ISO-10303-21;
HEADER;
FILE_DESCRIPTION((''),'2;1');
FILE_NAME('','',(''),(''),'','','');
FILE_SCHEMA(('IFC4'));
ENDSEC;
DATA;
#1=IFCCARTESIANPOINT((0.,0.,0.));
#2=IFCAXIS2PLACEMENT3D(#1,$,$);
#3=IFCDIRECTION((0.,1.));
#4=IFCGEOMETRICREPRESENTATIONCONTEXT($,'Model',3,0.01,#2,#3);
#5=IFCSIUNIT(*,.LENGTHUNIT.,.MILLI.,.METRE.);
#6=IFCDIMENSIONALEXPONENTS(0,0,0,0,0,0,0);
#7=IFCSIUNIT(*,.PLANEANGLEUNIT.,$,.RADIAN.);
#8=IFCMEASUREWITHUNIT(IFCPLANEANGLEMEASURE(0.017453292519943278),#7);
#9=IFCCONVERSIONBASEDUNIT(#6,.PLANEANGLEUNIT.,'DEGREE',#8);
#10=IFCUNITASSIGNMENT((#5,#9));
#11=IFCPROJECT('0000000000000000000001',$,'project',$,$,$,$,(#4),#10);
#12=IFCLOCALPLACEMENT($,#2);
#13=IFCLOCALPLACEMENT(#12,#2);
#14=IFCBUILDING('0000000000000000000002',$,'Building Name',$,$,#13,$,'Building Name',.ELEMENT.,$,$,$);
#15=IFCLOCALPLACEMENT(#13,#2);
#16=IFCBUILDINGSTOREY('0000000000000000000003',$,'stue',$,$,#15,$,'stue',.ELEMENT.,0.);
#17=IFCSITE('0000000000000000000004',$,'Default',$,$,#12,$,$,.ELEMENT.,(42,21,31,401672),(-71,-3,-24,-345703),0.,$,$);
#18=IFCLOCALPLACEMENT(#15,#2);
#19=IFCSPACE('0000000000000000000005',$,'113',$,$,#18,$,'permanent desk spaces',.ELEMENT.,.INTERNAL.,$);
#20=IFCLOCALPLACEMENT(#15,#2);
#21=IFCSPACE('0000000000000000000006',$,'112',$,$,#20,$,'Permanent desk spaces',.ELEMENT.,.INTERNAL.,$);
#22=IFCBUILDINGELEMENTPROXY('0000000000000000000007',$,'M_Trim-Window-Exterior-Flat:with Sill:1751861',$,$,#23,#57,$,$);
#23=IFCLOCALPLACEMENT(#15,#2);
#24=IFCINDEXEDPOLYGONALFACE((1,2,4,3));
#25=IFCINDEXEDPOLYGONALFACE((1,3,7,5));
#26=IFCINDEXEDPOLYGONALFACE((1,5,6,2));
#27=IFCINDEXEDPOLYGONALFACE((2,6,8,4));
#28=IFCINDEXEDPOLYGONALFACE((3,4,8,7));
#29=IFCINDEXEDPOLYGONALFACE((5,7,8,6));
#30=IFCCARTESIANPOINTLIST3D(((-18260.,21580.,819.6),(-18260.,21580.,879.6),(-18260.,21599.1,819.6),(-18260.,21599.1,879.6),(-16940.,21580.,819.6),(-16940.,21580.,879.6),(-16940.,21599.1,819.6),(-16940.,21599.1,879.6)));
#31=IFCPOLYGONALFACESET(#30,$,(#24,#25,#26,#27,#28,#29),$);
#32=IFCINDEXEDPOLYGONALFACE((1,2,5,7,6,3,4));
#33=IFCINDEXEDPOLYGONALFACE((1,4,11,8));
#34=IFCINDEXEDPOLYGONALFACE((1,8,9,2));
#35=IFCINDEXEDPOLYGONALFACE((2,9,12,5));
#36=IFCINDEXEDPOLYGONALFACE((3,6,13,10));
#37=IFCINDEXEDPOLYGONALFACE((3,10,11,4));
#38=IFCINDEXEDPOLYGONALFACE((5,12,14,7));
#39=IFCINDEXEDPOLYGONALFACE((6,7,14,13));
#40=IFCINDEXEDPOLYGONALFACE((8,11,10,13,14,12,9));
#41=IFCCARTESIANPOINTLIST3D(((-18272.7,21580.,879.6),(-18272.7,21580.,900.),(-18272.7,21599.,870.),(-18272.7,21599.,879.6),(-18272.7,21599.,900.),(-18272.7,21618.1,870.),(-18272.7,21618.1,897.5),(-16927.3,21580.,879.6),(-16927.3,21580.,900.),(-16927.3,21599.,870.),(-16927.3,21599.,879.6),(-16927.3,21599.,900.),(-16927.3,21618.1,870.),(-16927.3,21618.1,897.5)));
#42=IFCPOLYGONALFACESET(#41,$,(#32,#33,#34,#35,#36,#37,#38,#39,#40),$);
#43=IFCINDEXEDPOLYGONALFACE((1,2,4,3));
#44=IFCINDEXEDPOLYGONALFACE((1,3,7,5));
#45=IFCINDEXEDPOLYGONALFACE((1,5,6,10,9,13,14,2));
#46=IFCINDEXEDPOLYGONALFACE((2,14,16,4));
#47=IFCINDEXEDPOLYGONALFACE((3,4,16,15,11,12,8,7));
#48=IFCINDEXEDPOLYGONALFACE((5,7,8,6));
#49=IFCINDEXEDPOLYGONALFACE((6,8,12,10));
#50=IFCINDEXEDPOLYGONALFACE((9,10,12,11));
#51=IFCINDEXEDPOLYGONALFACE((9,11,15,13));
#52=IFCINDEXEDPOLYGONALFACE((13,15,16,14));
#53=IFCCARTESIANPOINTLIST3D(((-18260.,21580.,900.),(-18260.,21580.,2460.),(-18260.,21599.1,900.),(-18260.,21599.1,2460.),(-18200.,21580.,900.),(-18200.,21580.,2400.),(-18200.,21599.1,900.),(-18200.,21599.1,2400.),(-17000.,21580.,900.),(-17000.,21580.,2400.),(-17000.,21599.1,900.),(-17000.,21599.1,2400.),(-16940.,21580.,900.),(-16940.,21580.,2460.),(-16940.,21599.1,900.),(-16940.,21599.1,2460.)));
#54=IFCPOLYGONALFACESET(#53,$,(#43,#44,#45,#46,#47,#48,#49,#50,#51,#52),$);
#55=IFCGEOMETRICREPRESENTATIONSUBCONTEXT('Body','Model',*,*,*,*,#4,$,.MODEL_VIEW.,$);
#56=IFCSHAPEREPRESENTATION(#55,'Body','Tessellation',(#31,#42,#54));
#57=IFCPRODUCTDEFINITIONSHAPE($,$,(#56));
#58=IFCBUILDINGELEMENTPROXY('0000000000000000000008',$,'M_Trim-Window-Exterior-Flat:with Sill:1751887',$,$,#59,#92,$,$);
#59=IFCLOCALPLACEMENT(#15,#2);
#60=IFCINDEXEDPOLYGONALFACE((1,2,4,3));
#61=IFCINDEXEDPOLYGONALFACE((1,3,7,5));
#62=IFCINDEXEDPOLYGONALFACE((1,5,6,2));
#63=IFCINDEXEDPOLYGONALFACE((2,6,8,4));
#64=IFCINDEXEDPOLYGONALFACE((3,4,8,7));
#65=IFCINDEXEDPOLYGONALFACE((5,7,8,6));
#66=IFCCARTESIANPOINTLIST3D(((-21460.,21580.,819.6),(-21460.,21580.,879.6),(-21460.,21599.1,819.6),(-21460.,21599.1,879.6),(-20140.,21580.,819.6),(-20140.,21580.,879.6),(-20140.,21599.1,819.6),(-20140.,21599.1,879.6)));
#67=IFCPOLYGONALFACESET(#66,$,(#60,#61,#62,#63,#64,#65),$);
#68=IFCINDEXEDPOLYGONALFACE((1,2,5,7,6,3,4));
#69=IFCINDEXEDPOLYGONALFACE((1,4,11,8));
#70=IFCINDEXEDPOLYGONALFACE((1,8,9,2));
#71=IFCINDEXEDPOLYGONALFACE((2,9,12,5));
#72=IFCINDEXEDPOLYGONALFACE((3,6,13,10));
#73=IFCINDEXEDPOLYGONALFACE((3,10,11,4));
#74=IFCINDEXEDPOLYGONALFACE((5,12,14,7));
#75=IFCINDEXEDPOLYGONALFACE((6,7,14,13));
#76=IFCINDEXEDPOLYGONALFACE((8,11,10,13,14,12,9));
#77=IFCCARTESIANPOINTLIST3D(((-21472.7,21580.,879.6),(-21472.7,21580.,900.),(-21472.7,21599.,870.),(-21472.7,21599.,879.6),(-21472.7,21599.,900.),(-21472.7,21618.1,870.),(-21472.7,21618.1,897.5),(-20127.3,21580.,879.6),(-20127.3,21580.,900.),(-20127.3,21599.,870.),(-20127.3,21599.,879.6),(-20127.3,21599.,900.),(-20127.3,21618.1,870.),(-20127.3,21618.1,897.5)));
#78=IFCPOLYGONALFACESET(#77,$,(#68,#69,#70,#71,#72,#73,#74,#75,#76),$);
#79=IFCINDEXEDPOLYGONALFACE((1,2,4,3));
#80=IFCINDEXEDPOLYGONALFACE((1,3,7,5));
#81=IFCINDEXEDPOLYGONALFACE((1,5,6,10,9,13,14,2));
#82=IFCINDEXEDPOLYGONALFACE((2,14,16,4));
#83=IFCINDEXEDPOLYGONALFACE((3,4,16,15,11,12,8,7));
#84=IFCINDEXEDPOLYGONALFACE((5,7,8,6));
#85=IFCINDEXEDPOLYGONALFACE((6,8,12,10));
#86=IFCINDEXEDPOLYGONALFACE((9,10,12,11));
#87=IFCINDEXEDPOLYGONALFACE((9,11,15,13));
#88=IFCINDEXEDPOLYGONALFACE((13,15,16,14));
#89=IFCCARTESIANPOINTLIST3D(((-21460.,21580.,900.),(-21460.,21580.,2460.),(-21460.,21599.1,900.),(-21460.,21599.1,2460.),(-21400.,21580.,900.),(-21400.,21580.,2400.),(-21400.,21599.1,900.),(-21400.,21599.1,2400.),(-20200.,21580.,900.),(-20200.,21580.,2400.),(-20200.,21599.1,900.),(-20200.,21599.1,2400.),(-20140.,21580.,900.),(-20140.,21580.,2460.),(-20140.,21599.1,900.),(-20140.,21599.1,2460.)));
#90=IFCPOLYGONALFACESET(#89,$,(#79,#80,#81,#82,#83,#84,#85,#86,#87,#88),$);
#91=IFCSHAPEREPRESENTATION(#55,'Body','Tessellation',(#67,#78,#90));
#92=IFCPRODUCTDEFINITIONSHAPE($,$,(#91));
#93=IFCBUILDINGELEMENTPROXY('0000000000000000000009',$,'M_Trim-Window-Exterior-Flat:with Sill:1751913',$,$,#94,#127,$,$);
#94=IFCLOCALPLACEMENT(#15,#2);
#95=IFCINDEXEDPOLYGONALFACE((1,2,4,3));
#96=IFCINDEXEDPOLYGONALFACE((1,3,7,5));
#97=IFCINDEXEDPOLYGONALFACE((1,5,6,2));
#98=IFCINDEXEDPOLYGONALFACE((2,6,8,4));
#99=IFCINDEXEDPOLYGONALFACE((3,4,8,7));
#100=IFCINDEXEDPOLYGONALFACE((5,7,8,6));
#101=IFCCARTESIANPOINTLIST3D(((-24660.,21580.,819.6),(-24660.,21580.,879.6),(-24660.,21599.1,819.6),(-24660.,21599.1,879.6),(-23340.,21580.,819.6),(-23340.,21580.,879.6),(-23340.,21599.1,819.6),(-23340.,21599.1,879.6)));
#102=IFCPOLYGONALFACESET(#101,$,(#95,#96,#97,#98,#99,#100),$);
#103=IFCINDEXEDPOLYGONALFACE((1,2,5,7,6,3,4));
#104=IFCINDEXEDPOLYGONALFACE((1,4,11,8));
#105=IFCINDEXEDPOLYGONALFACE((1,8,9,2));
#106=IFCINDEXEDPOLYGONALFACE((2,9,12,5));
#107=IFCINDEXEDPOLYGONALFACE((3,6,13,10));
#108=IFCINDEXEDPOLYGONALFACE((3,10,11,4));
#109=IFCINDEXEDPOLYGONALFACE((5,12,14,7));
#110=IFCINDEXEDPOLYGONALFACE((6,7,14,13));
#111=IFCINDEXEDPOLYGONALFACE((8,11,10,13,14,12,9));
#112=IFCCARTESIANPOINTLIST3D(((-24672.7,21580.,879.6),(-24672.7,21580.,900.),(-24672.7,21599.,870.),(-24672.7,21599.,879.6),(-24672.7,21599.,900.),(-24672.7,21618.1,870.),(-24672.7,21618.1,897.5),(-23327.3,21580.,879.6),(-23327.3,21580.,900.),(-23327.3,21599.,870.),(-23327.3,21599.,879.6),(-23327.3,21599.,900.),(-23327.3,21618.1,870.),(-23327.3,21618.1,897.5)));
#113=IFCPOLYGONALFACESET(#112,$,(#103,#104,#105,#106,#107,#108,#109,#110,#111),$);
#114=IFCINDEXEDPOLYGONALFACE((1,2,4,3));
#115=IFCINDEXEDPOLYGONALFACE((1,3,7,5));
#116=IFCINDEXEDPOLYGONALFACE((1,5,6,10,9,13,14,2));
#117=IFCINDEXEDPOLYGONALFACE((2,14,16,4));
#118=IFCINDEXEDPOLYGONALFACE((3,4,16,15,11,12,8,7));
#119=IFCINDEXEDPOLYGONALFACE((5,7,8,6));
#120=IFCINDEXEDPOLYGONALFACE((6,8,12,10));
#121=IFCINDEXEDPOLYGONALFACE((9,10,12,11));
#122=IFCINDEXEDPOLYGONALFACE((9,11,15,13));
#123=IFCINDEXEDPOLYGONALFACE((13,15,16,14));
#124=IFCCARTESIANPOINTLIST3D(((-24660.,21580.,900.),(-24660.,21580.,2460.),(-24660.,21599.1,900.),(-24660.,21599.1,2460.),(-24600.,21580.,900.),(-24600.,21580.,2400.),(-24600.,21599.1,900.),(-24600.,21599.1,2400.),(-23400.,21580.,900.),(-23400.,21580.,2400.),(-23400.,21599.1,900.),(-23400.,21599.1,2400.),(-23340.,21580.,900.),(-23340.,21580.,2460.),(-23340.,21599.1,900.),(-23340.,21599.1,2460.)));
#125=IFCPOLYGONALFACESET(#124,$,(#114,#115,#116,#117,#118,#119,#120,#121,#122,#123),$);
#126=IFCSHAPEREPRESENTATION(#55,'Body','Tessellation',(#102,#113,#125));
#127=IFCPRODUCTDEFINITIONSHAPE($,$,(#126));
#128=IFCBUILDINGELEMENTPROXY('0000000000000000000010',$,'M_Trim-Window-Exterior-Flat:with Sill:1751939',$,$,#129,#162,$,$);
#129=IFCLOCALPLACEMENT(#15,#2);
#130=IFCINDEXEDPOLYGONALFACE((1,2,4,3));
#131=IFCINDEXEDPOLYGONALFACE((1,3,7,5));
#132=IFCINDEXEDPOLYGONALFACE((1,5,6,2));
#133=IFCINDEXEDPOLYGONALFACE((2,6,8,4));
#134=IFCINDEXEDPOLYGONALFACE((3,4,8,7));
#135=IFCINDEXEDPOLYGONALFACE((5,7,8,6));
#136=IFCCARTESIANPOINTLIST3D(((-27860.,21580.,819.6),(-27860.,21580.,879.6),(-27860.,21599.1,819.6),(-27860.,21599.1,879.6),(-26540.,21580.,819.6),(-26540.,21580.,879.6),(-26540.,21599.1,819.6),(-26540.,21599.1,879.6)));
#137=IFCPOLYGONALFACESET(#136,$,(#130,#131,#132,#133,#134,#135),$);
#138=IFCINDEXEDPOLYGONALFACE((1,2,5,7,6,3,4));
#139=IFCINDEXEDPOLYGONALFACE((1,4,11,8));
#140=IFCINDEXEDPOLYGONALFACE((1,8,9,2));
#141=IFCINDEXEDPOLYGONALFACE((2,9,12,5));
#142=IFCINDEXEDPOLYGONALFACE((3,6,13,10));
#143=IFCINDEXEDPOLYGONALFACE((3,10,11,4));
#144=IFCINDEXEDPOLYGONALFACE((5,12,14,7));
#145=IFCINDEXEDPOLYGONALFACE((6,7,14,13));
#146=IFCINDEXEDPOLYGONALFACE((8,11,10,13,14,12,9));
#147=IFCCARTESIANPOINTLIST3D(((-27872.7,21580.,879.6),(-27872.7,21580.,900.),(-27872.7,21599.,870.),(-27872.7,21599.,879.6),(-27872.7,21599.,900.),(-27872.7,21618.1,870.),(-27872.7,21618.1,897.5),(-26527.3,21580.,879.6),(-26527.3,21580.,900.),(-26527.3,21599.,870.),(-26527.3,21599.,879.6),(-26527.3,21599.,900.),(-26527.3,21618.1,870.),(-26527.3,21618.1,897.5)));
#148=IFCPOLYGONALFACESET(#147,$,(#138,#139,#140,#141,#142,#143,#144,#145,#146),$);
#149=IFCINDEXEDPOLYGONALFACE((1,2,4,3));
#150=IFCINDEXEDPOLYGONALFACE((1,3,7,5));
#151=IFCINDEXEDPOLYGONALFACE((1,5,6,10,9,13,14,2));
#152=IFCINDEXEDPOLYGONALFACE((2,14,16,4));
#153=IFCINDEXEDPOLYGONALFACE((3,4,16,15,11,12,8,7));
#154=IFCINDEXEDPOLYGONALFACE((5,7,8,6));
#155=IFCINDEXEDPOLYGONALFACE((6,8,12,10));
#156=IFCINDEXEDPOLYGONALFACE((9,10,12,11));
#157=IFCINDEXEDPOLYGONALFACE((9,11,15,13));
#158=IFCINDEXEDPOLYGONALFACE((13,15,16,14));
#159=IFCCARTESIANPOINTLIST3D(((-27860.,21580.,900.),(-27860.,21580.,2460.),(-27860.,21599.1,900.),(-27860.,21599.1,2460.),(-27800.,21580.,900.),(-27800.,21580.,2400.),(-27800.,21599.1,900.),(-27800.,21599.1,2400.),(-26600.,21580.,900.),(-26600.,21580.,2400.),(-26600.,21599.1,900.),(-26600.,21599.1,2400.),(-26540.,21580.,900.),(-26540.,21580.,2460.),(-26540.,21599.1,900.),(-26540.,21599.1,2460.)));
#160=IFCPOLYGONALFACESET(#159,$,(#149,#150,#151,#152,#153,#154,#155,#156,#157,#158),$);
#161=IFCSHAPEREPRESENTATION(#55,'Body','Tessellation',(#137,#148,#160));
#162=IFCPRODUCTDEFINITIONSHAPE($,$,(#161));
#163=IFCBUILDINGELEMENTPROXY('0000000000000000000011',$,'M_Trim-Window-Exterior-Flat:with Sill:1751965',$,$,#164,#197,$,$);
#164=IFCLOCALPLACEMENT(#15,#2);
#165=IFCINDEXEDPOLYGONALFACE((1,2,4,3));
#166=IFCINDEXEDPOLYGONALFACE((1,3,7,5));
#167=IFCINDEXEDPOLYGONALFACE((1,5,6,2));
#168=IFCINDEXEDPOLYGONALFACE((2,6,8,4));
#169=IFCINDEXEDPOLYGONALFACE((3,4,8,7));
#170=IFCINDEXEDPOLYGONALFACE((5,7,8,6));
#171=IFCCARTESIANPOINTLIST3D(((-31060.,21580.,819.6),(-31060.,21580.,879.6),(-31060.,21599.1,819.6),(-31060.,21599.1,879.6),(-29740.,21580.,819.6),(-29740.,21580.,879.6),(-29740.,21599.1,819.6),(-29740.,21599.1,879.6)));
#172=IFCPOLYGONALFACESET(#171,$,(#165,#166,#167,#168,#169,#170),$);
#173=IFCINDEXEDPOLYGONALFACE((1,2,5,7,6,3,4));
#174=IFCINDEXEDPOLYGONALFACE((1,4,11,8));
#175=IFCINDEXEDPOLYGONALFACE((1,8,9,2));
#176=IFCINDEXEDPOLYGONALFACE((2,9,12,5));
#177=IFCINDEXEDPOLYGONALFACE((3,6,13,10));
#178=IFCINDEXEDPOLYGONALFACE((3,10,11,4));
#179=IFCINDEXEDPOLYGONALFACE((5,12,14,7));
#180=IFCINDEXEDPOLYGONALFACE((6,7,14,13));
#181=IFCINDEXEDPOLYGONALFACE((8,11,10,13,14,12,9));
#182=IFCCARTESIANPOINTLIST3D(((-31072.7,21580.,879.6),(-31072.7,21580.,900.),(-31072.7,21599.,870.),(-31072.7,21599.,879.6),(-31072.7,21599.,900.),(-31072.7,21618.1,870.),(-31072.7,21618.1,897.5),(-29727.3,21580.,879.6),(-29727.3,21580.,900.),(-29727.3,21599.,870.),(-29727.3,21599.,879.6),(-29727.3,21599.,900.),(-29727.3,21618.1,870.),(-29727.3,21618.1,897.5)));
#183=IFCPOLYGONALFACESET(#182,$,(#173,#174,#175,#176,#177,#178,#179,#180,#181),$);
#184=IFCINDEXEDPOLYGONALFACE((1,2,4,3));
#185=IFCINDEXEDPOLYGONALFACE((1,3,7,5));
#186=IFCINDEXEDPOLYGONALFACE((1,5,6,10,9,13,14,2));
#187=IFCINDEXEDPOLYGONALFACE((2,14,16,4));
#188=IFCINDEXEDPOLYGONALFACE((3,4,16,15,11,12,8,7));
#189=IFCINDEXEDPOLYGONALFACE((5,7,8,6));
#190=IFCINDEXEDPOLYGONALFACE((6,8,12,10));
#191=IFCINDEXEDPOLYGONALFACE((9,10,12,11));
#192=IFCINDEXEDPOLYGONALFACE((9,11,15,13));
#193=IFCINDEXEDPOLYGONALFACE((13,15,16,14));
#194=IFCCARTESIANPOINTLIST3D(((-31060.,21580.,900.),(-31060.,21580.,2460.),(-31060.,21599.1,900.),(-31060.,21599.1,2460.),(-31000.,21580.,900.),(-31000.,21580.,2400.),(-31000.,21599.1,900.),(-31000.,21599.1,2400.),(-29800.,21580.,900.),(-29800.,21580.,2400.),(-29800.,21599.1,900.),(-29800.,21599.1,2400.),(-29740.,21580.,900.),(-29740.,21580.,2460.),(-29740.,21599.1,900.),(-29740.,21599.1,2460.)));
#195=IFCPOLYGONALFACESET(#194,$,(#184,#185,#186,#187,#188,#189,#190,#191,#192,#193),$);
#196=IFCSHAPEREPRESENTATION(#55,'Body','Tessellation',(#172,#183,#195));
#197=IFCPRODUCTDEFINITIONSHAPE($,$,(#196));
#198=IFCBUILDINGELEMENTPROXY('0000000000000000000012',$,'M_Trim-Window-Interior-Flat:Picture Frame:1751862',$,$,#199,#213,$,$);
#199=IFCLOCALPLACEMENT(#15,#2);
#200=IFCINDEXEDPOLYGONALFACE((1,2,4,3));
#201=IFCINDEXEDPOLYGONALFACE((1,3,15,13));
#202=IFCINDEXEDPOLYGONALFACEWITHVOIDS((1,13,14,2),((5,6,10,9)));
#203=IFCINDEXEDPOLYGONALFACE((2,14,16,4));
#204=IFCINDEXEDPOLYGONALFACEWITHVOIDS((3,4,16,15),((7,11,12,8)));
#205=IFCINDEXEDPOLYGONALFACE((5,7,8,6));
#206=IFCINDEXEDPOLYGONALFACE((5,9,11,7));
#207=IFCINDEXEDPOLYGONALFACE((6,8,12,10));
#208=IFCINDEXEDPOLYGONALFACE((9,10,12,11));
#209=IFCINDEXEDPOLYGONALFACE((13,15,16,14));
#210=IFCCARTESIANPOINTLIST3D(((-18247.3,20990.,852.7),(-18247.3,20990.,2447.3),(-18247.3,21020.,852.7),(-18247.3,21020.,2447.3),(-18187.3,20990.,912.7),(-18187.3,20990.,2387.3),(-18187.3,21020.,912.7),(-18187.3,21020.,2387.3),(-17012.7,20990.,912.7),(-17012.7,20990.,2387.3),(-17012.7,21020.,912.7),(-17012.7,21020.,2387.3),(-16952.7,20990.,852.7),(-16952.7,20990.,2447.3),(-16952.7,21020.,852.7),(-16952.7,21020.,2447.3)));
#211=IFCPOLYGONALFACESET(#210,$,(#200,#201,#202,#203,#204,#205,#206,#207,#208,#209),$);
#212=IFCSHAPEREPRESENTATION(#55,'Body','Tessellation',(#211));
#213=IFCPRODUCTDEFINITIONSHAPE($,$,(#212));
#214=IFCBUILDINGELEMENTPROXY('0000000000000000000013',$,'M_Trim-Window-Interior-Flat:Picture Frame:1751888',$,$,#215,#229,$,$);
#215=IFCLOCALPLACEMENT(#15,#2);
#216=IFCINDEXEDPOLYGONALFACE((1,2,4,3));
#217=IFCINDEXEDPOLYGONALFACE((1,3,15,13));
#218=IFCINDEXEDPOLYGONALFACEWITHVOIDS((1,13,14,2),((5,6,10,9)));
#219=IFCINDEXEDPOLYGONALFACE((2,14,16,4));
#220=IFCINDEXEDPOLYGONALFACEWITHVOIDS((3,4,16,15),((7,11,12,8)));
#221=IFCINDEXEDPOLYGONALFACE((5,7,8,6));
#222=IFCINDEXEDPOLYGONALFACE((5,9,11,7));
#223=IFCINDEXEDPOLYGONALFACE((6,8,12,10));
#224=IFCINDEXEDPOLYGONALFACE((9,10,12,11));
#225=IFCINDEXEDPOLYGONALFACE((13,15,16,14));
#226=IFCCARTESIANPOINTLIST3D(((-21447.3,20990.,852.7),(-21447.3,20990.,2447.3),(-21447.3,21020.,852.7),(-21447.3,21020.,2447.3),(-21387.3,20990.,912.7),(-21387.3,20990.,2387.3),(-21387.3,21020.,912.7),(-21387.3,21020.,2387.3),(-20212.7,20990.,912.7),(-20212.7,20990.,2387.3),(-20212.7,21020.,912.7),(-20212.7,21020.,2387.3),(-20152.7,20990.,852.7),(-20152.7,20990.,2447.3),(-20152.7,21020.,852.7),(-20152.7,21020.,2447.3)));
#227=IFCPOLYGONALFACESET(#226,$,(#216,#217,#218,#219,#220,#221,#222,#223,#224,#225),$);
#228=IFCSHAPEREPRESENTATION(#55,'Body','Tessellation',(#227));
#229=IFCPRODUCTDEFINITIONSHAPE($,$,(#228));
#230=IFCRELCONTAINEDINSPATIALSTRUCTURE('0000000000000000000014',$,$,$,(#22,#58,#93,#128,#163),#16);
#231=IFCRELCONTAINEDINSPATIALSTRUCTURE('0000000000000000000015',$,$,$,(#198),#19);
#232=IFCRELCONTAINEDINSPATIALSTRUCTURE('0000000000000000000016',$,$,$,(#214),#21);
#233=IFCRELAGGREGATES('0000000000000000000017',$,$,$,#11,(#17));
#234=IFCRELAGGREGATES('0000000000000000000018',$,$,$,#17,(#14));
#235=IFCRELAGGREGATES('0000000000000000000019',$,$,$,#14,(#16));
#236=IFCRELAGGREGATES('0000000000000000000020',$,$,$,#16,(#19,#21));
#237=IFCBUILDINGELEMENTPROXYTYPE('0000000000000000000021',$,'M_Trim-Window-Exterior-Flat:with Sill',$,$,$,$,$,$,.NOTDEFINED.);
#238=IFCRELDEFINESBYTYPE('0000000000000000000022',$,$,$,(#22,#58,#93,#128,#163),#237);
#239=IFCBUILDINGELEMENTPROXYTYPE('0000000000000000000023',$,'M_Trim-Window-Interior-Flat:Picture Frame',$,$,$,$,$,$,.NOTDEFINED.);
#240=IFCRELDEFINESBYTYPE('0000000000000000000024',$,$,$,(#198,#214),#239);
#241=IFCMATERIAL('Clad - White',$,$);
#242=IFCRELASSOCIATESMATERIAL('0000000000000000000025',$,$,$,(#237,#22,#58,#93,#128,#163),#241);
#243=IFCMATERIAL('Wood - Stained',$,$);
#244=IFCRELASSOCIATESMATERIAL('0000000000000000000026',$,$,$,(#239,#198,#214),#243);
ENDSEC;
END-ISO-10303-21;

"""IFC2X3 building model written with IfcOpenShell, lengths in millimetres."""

from ifc_helpers import new_model, entity, si_unit, converted_unit, direction, frame, frame_2d, origin, place, context, subcontext, project, spatial, polyline, rectangle, outline, extrude, source, transform, mapped, material, type_object, type_shapes, element, save


model = new_model("IFC2X3")

# Units and contexts
model_context = context("Model", 3, precision=0.01, world=origin(), true_north=direction((0.0, 1.0)))
body_context = subcontext(model_context, "Body", "Model", "MODEL_VIEW")
ifc_project = project(units=[si_unit("LENGTHUNIT", "METRE", prefix="MILLI"), converted_unit("PLANEANGLEUNIT", "DEGREE", entity("IfcPlaneAngleMeasure", 0.017453292519943278), si_unit("PLANEANGLEUNIT", "RADIAN"), dimensions=[0, 0, 0, 0, 0, 0, 0])], contexts=[model_context])

# Site, building, storey
site_placement = place(None, origin())
site = spatial("IfcSite", under=ifc_project, at=site_placement, Name="Default", CompositionType="ELEMENT", RefLatitude=(42, 21, 31, 401672), RefLongitude=(-71, -3, -24, -345703), RefElevation=0.0)
building_placement = place(site_placement, origin())
building = spatial("IfcBuilding", under=site, at=building_placement, Name="Building Name", LongName="Building Name", CompositionType="ELEMENT")
storey_placement = place(building_placement, origin())
storey = spatial("IfcBuildingStorey", under=building, at=storey_placement, Name="stue", LongName="stue", CompositionType="ELEMENT", Elevation=0.0)

# Building element proxies
ifc_material_1 = material(Name="Clad - White")
ifc_material_2 = material(Name="Wood - Stained")
building_element_proxy_type_1 = type_object("IfcBuildingElementProxyType", Name="M_Trim-Window-Exterior-Flat:with Sill", PredefinedType="NOTDEFINED", material=ifc_material_1)
shared_shape_1 = source(origin(), body_context, "Body", "SweptSolid", [
    extrude(rectangle(XDim=1320.0, YDim=60.0, at=frame_2d((0.0, 0.0), x_axis=(1.0, 0.0))), frame((0.0, -1550.4, 0.0), z_axis=(0.0, 0.0, 1.0), x_axis=(-1.0, 0.0, 0.0)), (0.0, 0.0, 1.0), 19.0),
    extrude(outline(polyline([(-19.0, -15.2), (0.0, -15.2), (0.0, -5.7), (19.0, -5.7), (19.0, 14.8), (0.0, 14.8), (-19.0, 12.3), (-19.0, -15.2)])), frame((-672.7, -1514.8, 19.0), z_axis=(1.0, 0.0, 0.0), x_axis=(0.0, 0.0, -1.0)), (0.0, 0.0, 1.0), 1345.4),
    extrude(outline(polyline([(-795.0, -660.0), (765.0, -660.0), (765.0, -600.0), (-735.0, -600.0), (-735.0, 600.0), (765.0, 600.0), (765.0, 660.0), (-795.0, 660.0), (-795.0, -660.0)])), frame((0.0, -735.0, 0.0), z_axis=(0.0, 0.0, 1.0), x_axis=(0.0, -1.0, 0.0)), (0.0, 0.0, 1.0), 19.0),
])
type_shapes(building_element_proxy_type_1, [shared_shape_1])
for number, where, z_axis, x_axis, name in (
    (1, (-17600.0, 21580.0, 2400.0), (0.0, 1.0, 0.0), (-1.0, 0.0, 0.0), "M_Trim-Window-Exterior-Flat:with Sill:1751861"),
    (2, (-20800.0, 21580.0, 2400.0), (0.0, 1.0, 0.0), (-1.0, 0.0, 0.0), "M_Trim-Window-Exterior-Flat:with Sill:1751887"),
    (3, (-24000.0, 21580.0, 2400.0), (0.0, 1.0, 0.0), (-1.0, 0.0, 0.0), "M_Trim-Window-Exterior-Flat:with Sill:1751913"),
    (4, (-27200.0, 21580.0, 2400.0), (0.0, 1.0, 0.0), (-1.0, 0.0, 0.0), "M_Trim-Window-Exterior-Flat:with Sill:1751939"),
    (5, (-30400.0, 21580.0, 2400.0), (0.0, 1.0, 0.0), (-1.0, 0.0, 0.0), "M_Trim-Window-Exterior-Flat:with Sill:1751965"),
):
    element("IfcBuildingElementProxy", number, at=place(storey_placement, frame(where, z_axis=z_axis, x_axis=x_axis)), inside=storey, type_object=building_element_proxy_type_1, material=ifc_material_1, Name=name, context=body_context, shape_type="MappedRepresentation", body=[
        mapped(shared_shape_1, transform((0.0, 0.0, 0.0), scale=1.0)),
    ])

# Shared definitions
space_1_placement = place(storey_placement, origin())
space_1 = spatial("IfcSpace", under=storey, at=space_1_placement, Name="113", LongName="permanent desk spaces", CompositionType="ELEMENT", InteriorOrExteriorSpace="INTERNAL")

# Building element proxy
building_element_proxy_type_2 = type_object("IfcBuildingElementProxyType", Name="M_Trim-Window-Interior-Flat:Picture Frame", PredefinedType="NOTDEFINED", material=ifc_material_2)
shared_shape_2 = source(origin(), body_context, "Body", "SweptSolid", [
    extrude(outline(polyline([(-647.3, -797.3), (647.3, -797.3), (647.3, 797.3), (-647.3, 797.3), (-647.3, -797.3)]), holes=[polyline([(-587.3, -737.3), (-587.3, 737.3), (587.3, 737.3), (587.3, -737.3), (-587.3, -737.3)])]), frame((0.0, -750.0, 0.0), z_axis=(0.0, 0.0, 1.0), x_axis=(-1.0, 0.0, 0.0)), (0.0, 0.0, 1.0), 30.0),
])
type_shapes(building_element_proxy_type_2, [shared_shape_2])
proxy_1_placement = place(space_1_placement, frame((-17600.0, 21020.0, 2400.0), z_axis=(0.0, -1.0, 0.0), x_axis=(1.0, 0.0, 0.0)))
element("IfcBuildingElementProxy", 6, at=proxy_1_placement, inside=space_1, type_object=building_element_proxy_type_2, material=ifc_material_2, Name="M_Trim-Window-Interior-Flat:Picture Frame:1751862", context=body_context, shape_type="MappedRepresentation", body=[
    mapped(shared_shape_2, transform((0.0, 0.0, 0.0), scale=1.0)),
])

# Shared definitions
space_2_placement = place(storey_placement, origin())
space_2 = spatial("IfcSpace", under=storey, at=space_2_placement, Name="112", LongName="Permanent desk spaces", CompositionType="ELEMENT", InteriorOrExteriorSpace="INTERNAL")

# Building element proxy
proxy_2_placement = place(space_2_placement, frame((-20800.0, 21020.0, 2400.0), z_axis=(0.0, -1.0, 0.0), x_axis=(1.0, 0.0, 0.0)))
element("IfcBuildingElementProxy", 7, at=proxy_2_placement, inside=space_2, type_object=building_element_proxy_type_2, material=ifc_material_2, Name="M_Trim-Window-Interior-Flat:Picture Frame:1751888", context=body_context, shape_type="MappedRepresentation", body=[
    mapped(shared_shape_2, transform((0.0, 0.0, 0.0), scale=1.0)),
])

save(model, "model.ifc")
